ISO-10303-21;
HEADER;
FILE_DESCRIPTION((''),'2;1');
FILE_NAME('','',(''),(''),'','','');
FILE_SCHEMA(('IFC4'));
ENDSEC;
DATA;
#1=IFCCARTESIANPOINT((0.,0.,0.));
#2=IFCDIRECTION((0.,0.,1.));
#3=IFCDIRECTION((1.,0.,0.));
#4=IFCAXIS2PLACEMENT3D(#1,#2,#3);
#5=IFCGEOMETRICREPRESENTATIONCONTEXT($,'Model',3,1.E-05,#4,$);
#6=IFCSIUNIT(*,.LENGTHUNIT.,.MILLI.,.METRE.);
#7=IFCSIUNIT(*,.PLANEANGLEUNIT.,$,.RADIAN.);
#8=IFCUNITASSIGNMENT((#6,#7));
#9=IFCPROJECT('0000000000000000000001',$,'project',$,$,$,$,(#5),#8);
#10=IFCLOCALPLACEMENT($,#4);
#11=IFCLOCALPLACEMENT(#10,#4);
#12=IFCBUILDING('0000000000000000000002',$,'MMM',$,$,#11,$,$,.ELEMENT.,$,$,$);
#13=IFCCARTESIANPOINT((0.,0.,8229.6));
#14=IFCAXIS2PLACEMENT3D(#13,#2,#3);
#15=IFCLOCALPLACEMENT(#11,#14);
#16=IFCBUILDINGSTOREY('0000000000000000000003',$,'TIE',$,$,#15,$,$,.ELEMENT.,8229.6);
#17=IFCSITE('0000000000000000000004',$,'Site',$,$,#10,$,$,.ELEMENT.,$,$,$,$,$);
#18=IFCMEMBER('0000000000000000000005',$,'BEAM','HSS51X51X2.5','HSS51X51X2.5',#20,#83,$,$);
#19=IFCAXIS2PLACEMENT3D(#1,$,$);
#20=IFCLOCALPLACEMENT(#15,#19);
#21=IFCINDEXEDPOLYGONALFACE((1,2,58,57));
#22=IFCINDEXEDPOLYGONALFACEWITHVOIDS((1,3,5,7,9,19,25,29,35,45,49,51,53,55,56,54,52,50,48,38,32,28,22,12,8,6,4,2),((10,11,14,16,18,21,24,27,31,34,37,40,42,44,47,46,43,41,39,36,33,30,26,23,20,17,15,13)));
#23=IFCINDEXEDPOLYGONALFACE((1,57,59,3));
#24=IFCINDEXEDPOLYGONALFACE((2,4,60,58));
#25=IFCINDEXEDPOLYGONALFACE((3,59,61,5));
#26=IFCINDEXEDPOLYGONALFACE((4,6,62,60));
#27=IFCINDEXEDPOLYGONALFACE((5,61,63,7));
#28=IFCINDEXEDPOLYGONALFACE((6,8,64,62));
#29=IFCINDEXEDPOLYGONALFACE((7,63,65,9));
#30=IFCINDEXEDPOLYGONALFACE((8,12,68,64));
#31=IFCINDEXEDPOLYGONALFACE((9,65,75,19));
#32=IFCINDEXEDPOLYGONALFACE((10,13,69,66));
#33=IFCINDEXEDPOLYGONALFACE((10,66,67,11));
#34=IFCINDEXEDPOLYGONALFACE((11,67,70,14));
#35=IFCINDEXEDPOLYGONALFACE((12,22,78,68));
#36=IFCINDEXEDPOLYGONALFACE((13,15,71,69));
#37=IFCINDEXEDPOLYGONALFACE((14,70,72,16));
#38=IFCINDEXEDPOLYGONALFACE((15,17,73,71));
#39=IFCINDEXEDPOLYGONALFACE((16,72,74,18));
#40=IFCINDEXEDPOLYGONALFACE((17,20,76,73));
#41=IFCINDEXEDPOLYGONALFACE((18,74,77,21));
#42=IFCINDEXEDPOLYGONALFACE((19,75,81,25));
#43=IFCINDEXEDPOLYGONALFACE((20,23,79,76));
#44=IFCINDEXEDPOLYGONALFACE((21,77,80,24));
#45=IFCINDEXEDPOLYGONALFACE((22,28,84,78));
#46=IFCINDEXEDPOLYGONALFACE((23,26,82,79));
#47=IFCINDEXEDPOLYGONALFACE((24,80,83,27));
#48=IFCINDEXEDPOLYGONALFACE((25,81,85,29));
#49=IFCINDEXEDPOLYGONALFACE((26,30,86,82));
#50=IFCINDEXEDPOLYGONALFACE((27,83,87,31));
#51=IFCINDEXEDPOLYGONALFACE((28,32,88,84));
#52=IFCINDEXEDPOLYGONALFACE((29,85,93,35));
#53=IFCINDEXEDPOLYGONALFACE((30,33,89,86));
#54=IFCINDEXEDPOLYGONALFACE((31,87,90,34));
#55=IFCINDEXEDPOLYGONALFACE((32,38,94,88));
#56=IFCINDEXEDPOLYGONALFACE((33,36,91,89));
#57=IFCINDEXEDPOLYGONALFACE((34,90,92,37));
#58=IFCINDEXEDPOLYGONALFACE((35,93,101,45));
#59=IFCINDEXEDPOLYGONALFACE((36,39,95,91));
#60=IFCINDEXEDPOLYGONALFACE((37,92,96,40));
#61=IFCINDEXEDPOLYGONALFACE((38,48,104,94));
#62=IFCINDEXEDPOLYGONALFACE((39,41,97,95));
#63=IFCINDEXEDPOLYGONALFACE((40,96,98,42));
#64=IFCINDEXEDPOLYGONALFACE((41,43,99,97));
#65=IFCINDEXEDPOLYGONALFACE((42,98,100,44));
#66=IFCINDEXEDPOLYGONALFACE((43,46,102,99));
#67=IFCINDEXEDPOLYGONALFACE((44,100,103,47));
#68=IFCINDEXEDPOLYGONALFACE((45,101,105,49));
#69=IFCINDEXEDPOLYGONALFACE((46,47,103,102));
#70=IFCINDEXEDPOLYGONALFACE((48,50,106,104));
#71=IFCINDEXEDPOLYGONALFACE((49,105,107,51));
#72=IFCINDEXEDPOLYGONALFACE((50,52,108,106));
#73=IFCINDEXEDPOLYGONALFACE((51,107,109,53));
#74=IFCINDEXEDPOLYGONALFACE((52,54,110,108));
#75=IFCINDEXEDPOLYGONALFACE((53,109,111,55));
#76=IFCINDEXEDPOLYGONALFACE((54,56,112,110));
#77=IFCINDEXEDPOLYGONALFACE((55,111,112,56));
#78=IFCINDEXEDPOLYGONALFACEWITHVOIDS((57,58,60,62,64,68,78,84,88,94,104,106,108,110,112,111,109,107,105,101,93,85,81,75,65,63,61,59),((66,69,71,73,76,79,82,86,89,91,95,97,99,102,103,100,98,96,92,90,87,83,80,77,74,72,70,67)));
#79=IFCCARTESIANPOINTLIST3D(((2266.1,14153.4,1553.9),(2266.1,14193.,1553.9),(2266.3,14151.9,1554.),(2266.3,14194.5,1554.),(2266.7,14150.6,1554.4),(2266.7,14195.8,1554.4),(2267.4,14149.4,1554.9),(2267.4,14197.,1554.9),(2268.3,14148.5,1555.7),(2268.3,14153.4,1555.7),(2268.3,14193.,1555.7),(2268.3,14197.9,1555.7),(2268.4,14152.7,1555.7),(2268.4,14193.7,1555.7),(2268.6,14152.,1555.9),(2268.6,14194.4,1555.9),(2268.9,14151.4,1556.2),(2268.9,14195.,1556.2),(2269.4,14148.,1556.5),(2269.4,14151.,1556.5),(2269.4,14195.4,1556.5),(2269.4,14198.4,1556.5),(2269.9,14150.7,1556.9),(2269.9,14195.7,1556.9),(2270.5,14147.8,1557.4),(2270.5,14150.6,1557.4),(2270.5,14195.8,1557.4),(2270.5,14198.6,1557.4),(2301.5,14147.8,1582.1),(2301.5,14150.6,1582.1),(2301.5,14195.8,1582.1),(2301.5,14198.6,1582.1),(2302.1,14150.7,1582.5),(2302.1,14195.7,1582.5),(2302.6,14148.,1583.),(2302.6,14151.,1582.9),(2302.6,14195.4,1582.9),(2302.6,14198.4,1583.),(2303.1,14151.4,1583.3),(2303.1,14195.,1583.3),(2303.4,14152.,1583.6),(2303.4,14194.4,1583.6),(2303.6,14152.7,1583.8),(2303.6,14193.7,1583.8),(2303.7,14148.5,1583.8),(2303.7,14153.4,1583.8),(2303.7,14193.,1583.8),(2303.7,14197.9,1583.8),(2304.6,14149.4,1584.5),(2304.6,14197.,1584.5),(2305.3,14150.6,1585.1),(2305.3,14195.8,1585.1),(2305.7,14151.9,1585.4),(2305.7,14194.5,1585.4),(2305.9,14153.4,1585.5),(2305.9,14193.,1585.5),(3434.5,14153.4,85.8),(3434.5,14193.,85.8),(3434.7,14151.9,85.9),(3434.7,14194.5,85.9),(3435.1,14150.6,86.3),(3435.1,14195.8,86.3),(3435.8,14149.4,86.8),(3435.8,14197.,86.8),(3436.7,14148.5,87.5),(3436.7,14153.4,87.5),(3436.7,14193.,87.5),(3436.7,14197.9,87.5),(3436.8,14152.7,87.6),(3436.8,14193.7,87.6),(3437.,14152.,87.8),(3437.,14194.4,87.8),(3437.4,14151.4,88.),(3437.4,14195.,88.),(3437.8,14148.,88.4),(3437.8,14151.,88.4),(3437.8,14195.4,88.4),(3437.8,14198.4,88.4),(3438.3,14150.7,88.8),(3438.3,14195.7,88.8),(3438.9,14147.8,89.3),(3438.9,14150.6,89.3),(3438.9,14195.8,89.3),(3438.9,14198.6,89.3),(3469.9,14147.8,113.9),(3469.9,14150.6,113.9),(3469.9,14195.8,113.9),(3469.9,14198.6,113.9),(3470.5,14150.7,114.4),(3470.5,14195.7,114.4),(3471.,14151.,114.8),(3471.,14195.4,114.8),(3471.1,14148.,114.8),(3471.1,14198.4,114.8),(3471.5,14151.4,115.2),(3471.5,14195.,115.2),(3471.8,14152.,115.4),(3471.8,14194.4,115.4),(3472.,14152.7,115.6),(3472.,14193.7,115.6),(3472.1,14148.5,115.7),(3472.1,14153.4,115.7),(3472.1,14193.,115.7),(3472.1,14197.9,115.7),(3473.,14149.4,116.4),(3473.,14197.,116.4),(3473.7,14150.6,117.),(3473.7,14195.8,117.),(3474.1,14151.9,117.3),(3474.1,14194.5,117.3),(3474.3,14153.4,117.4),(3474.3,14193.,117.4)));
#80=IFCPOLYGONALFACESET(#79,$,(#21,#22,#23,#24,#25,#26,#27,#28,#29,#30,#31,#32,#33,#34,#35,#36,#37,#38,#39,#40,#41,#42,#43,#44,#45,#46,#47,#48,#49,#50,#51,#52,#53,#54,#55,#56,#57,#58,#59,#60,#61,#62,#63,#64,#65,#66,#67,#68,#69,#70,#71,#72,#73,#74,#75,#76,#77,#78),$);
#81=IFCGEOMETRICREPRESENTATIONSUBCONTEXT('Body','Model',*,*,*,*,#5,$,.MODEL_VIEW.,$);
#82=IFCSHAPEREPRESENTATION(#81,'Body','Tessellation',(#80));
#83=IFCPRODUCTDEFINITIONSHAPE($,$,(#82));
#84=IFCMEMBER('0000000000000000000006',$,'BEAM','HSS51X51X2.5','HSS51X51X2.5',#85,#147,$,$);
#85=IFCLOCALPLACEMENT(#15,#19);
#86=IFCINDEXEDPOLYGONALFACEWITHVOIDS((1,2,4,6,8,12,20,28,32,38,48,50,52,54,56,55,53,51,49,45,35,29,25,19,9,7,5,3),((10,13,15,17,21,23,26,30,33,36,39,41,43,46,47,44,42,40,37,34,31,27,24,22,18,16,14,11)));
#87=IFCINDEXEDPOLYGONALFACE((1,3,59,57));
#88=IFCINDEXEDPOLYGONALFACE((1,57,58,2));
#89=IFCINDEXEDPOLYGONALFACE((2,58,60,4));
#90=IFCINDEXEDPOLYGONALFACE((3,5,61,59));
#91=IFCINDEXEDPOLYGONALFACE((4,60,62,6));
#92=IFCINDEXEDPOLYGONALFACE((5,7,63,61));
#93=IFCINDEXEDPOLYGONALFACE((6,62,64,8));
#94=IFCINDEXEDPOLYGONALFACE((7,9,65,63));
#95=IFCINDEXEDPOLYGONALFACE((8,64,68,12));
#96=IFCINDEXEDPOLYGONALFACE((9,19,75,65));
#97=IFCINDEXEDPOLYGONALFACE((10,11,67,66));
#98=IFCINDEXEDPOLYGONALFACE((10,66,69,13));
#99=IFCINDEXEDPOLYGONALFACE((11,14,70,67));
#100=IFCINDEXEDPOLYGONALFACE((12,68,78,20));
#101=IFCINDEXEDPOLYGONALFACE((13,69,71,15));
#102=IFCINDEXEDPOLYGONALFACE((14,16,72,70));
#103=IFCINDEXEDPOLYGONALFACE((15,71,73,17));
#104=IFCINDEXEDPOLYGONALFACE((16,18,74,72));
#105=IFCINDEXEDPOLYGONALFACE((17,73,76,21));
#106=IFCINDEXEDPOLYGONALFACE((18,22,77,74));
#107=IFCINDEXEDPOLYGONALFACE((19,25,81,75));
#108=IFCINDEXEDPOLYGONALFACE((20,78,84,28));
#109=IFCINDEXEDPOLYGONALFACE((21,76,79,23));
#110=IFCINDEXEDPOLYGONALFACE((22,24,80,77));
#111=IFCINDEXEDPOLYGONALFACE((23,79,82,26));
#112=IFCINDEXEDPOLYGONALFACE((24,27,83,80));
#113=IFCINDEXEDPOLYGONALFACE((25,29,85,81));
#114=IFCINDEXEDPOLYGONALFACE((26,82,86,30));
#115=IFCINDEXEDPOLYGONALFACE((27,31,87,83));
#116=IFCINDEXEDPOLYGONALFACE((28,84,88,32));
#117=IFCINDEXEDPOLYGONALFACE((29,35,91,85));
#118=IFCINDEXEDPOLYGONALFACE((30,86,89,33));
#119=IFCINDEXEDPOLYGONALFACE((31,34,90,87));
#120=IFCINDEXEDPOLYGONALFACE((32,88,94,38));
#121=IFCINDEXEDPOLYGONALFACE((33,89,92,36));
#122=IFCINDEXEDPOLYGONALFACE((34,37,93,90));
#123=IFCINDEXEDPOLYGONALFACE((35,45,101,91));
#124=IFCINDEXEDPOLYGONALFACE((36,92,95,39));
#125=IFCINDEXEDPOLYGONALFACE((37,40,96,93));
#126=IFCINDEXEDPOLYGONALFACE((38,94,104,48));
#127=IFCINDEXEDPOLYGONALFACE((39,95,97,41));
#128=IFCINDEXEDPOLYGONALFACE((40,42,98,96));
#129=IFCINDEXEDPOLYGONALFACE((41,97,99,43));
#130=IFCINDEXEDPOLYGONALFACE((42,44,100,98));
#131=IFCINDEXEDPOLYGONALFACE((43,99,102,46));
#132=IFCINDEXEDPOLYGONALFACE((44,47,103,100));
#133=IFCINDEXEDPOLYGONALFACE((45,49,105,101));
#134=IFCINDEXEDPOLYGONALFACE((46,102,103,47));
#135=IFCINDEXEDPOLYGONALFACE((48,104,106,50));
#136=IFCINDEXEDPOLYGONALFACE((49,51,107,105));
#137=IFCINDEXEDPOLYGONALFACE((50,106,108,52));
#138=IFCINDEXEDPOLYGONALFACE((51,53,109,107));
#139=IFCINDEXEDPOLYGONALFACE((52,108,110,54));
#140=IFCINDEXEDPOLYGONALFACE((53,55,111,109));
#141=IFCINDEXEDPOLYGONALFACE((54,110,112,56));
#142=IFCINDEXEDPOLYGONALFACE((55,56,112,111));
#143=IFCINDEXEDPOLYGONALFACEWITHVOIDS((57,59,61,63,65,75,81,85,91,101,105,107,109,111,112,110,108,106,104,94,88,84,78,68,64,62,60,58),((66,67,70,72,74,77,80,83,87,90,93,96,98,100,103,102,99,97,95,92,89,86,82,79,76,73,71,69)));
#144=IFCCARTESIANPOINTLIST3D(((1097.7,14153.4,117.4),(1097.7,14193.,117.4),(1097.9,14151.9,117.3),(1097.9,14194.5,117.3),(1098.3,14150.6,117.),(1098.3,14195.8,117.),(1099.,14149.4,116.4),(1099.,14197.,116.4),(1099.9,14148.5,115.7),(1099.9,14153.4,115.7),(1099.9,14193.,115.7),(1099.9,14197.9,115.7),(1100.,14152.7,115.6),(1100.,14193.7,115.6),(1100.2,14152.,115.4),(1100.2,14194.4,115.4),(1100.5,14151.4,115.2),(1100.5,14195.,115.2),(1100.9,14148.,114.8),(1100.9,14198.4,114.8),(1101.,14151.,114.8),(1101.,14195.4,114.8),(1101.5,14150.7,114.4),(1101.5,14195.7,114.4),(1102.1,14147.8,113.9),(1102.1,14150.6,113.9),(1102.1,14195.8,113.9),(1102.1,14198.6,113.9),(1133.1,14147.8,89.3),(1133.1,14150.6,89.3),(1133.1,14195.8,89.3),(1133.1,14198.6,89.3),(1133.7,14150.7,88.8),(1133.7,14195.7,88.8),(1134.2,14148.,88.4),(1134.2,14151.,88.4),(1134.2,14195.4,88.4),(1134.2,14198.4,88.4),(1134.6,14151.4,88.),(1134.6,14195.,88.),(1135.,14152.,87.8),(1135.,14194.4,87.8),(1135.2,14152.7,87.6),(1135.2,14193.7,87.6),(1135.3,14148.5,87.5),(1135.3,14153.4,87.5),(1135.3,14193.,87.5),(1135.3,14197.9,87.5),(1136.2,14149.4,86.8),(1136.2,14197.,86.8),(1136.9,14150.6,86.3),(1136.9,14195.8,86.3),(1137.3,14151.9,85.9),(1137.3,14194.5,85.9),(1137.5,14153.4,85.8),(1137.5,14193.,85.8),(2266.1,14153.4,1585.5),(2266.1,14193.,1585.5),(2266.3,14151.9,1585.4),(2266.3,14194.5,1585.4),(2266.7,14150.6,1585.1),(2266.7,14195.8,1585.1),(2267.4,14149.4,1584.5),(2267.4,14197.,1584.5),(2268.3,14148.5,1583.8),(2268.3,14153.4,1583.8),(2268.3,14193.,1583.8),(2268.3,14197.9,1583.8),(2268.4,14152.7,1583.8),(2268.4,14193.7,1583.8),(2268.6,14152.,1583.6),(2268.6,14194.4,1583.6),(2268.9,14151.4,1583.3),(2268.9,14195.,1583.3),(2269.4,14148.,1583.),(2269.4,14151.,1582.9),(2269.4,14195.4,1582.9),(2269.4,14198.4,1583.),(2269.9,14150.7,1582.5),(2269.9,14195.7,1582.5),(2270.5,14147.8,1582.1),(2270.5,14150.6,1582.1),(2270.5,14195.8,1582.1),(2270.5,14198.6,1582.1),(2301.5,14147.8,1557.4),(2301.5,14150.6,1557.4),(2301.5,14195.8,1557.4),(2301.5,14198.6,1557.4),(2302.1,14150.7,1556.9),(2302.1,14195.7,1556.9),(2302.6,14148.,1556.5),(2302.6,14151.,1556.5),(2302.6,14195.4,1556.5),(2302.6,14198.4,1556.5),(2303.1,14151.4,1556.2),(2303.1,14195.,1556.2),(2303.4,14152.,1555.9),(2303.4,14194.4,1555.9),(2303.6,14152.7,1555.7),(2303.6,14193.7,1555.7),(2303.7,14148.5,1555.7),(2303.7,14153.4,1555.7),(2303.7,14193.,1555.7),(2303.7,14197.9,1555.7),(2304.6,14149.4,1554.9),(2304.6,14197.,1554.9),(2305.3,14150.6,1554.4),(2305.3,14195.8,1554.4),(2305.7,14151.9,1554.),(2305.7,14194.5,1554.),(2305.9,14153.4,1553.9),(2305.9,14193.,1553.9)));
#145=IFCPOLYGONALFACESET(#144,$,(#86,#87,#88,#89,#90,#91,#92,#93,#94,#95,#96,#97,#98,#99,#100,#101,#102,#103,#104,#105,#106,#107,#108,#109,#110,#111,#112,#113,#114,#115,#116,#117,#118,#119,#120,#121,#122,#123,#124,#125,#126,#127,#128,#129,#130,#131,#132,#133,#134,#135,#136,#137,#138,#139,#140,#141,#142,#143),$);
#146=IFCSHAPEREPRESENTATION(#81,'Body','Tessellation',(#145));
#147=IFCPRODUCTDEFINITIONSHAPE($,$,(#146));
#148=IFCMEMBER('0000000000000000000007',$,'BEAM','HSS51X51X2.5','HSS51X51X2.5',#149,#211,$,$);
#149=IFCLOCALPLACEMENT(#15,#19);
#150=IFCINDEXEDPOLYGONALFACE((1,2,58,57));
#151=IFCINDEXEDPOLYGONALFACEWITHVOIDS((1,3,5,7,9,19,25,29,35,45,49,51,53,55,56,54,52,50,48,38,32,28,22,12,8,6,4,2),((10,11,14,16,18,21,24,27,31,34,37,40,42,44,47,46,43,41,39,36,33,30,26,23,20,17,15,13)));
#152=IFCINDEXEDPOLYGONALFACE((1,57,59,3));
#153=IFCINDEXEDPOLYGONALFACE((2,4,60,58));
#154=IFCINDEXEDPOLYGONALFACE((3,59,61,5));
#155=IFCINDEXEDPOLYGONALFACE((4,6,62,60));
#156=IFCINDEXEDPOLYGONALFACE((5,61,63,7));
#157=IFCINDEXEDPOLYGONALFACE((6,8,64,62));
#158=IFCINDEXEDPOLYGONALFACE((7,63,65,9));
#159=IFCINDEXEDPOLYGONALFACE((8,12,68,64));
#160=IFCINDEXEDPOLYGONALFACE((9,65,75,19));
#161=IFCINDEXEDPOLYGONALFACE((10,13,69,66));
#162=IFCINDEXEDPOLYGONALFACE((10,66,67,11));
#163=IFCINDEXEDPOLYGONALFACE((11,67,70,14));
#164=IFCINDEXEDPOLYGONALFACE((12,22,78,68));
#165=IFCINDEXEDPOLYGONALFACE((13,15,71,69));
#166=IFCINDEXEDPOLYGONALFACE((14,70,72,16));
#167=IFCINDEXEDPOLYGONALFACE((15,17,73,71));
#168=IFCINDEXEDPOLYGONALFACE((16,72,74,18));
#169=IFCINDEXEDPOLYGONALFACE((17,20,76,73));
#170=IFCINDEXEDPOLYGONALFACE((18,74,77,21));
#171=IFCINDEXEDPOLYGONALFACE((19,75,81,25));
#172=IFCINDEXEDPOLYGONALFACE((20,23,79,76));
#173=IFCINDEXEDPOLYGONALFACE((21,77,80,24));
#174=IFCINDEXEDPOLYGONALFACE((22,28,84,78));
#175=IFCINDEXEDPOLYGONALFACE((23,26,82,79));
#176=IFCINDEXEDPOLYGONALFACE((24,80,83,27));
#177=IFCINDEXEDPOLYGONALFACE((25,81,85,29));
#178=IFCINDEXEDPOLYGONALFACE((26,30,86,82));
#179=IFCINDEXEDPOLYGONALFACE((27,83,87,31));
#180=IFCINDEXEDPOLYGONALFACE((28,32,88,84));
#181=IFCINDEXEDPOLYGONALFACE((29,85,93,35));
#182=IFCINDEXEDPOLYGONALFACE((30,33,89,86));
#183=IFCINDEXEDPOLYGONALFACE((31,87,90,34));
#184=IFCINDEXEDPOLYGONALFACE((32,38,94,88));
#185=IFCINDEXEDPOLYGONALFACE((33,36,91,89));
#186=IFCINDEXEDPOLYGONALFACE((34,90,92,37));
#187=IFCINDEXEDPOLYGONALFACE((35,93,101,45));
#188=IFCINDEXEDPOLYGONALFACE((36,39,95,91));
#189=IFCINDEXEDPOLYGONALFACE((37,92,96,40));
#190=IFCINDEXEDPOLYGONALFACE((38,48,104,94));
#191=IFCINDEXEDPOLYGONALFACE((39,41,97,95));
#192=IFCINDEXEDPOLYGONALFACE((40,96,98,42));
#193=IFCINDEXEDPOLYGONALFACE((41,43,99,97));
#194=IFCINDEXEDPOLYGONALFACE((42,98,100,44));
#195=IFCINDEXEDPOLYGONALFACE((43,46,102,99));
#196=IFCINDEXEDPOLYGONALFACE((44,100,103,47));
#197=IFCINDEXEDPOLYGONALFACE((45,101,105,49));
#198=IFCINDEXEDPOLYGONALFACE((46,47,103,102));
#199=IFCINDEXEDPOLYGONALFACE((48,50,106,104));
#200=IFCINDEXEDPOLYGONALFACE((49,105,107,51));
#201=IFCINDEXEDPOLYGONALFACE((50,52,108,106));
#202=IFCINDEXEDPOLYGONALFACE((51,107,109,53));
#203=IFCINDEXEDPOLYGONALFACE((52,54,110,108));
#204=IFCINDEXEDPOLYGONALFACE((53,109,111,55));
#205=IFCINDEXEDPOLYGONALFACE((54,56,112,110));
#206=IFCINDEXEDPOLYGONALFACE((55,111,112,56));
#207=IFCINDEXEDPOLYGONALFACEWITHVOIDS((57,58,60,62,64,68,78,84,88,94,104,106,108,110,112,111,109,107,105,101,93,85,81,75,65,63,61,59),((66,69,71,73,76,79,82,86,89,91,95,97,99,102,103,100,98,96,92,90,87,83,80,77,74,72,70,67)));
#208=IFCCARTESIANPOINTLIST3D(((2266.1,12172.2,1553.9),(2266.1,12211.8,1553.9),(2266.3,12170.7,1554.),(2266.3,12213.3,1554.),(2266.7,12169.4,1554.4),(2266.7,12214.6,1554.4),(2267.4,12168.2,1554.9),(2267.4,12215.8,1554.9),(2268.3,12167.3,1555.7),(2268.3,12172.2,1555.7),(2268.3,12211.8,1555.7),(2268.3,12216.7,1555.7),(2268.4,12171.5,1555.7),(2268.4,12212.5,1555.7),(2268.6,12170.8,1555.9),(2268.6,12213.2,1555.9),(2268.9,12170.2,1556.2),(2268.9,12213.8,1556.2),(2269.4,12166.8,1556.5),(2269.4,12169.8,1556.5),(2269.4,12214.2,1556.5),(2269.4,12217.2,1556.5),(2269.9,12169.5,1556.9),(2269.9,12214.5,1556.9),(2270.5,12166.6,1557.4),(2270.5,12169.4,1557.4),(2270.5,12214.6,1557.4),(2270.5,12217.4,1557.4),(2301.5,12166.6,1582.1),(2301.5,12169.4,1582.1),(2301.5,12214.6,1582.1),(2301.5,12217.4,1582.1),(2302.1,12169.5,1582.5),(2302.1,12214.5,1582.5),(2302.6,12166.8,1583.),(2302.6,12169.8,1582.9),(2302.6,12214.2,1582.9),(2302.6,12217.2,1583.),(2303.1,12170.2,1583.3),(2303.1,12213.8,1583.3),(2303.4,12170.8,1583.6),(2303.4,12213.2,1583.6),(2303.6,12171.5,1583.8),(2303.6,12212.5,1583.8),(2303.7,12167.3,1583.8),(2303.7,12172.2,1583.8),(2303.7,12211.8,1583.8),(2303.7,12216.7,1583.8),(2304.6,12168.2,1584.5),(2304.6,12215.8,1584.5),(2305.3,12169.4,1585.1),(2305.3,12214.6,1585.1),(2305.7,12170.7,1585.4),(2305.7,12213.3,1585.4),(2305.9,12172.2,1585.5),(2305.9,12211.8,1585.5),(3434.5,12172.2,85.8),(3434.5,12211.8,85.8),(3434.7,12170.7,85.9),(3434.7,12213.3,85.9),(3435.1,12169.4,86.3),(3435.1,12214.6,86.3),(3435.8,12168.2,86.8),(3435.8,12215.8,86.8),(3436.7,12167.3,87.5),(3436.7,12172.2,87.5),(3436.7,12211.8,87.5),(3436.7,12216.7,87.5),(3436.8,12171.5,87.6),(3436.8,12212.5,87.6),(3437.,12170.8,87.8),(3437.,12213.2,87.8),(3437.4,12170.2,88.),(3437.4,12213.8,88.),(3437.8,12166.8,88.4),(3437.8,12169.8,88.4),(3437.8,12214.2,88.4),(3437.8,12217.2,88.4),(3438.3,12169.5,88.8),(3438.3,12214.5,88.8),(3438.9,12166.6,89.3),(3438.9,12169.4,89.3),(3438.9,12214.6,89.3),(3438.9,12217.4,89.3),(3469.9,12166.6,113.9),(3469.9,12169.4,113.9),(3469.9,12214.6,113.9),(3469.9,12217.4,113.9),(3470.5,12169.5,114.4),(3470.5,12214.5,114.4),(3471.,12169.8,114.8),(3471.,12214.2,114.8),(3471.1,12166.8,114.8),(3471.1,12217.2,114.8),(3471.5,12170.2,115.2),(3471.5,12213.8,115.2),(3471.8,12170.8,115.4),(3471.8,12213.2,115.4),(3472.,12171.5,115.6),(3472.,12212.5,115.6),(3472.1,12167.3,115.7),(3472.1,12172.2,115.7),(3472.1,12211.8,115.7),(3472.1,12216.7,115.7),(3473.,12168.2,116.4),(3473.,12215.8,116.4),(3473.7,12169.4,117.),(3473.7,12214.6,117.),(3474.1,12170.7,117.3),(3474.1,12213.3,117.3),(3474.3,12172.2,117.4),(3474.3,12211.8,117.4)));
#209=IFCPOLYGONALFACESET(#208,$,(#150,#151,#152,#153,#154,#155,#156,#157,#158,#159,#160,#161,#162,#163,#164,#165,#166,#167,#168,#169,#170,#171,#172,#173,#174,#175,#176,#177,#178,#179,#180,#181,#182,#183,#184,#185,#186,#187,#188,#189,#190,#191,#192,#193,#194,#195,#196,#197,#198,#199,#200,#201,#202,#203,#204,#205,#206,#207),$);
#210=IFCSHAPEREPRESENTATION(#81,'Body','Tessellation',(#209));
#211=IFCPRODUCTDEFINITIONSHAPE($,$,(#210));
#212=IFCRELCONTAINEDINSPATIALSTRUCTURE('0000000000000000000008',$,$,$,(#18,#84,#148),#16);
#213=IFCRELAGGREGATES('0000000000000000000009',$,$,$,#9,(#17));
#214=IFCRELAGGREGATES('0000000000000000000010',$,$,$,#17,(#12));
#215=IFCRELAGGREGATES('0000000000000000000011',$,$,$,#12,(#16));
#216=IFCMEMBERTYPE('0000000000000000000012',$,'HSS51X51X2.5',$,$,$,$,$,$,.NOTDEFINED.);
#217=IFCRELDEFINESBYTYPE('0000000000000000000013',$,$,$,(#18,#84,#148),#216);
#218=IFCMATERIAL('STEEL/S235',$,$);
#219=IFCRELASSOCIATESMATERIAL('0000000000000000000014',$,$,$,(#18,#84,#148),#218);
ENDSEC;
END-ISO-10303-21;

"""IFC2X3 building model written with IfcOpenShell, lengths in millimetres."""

from ifc_helpers import new_model, si_unit, frame, origin_with_axes, origin_2d_with_axis, place, context, subcontext, project, spatial, hollow_rectangle, extrude, material, type_object, element, save


model = new_model("IFC2X3")

# Units and contexts
model_context = context("Model", 3, precision=1e-05, world=origin_with_axes())
body_context = subcontext(model_context, "Body", "Model", "MODEL_VIEW")
ifc_project = project(units=[si_unit("LENGTHUNIT", "METRE", prefix="MILLI"), si_unit("PLANEANGLEUNIT", "RADIAN")], contexts=[model_context])

# Site, building, storey
site_placement = place(None, origin_with_axes())
site = spatial("IfcSite", under=ifc_project, at=site_placement, Name="Site", CompositionType="ELEMENT")
building_placement = place(site_placement, origin_with_axes())
building = spatial("IfcBuilding", under=site, at=building_placement, Name="MMM", CompositionType="ELEMENT")
storey_placement = place(building_placement, frame((0.0, 0.0, 8229.6), z_axis=(0.0, 0.0, 1.0), x_axis=(1.0, 0.0, 0.0)))
storey = spatial("IfcBuildingStorey", under=building, at=storey_placement, Name="TIE", CompositionType="ELEMENT", Elevation=8229.6)

# Shared definitions
ifc_material = material(Name="STEEL/S235")

# Members
member_type_1 = type_object("IfcMemberType", Name="HSS51X51X2.5", PredefinedType="NOTDEFINED")
for number, where, z_axis, x_axis, name in (
    (1, (3454.4, 14173.2, 101.6), (0.782448, 0.0, 0.622716), (-0.622716, 0.0, 0.782448), "BEAM"),
    (2, (1117.6, 14173.2, 101.6), (-0.782448, 0.0, 0.622716), (0.622716, 0.0, 0.782448), "BEAM"),
    (3, (3454.4, 12192.0, 101.6), (0.782448, 0.0, 0.622716), (-0.622716, 0.0, 0.782448), "BEAM"),
):
    element("IfcMember", number, at=place(storey_placement, frame(where, z_axis=z_axis, x_axis=x_axis)), inside=storey, type_object=member_type_1, material=ifc_material, Name=name, Description="HSS51X51X2.5", ObjectType="HSS51X51X2.5", context=body_context, shape_type="SweptSolid", body=[
        extrude(hollow_rectangle(XDim=50.8, YDim=50.8, WallThickness=2.8, InnerFilletRadius=2.8, OuterFilletRadius=5.6, at=origin_2d_with_axis()), frame((1876.3, 0.0, 0.0), z_axis=(-1.0, 0.0, 0.0), x_axis=(0.0, -1.0, 0.0)), (0.0, 0.0, 1.0), 1876.3),
    ])

save(model, "model.ifc")
